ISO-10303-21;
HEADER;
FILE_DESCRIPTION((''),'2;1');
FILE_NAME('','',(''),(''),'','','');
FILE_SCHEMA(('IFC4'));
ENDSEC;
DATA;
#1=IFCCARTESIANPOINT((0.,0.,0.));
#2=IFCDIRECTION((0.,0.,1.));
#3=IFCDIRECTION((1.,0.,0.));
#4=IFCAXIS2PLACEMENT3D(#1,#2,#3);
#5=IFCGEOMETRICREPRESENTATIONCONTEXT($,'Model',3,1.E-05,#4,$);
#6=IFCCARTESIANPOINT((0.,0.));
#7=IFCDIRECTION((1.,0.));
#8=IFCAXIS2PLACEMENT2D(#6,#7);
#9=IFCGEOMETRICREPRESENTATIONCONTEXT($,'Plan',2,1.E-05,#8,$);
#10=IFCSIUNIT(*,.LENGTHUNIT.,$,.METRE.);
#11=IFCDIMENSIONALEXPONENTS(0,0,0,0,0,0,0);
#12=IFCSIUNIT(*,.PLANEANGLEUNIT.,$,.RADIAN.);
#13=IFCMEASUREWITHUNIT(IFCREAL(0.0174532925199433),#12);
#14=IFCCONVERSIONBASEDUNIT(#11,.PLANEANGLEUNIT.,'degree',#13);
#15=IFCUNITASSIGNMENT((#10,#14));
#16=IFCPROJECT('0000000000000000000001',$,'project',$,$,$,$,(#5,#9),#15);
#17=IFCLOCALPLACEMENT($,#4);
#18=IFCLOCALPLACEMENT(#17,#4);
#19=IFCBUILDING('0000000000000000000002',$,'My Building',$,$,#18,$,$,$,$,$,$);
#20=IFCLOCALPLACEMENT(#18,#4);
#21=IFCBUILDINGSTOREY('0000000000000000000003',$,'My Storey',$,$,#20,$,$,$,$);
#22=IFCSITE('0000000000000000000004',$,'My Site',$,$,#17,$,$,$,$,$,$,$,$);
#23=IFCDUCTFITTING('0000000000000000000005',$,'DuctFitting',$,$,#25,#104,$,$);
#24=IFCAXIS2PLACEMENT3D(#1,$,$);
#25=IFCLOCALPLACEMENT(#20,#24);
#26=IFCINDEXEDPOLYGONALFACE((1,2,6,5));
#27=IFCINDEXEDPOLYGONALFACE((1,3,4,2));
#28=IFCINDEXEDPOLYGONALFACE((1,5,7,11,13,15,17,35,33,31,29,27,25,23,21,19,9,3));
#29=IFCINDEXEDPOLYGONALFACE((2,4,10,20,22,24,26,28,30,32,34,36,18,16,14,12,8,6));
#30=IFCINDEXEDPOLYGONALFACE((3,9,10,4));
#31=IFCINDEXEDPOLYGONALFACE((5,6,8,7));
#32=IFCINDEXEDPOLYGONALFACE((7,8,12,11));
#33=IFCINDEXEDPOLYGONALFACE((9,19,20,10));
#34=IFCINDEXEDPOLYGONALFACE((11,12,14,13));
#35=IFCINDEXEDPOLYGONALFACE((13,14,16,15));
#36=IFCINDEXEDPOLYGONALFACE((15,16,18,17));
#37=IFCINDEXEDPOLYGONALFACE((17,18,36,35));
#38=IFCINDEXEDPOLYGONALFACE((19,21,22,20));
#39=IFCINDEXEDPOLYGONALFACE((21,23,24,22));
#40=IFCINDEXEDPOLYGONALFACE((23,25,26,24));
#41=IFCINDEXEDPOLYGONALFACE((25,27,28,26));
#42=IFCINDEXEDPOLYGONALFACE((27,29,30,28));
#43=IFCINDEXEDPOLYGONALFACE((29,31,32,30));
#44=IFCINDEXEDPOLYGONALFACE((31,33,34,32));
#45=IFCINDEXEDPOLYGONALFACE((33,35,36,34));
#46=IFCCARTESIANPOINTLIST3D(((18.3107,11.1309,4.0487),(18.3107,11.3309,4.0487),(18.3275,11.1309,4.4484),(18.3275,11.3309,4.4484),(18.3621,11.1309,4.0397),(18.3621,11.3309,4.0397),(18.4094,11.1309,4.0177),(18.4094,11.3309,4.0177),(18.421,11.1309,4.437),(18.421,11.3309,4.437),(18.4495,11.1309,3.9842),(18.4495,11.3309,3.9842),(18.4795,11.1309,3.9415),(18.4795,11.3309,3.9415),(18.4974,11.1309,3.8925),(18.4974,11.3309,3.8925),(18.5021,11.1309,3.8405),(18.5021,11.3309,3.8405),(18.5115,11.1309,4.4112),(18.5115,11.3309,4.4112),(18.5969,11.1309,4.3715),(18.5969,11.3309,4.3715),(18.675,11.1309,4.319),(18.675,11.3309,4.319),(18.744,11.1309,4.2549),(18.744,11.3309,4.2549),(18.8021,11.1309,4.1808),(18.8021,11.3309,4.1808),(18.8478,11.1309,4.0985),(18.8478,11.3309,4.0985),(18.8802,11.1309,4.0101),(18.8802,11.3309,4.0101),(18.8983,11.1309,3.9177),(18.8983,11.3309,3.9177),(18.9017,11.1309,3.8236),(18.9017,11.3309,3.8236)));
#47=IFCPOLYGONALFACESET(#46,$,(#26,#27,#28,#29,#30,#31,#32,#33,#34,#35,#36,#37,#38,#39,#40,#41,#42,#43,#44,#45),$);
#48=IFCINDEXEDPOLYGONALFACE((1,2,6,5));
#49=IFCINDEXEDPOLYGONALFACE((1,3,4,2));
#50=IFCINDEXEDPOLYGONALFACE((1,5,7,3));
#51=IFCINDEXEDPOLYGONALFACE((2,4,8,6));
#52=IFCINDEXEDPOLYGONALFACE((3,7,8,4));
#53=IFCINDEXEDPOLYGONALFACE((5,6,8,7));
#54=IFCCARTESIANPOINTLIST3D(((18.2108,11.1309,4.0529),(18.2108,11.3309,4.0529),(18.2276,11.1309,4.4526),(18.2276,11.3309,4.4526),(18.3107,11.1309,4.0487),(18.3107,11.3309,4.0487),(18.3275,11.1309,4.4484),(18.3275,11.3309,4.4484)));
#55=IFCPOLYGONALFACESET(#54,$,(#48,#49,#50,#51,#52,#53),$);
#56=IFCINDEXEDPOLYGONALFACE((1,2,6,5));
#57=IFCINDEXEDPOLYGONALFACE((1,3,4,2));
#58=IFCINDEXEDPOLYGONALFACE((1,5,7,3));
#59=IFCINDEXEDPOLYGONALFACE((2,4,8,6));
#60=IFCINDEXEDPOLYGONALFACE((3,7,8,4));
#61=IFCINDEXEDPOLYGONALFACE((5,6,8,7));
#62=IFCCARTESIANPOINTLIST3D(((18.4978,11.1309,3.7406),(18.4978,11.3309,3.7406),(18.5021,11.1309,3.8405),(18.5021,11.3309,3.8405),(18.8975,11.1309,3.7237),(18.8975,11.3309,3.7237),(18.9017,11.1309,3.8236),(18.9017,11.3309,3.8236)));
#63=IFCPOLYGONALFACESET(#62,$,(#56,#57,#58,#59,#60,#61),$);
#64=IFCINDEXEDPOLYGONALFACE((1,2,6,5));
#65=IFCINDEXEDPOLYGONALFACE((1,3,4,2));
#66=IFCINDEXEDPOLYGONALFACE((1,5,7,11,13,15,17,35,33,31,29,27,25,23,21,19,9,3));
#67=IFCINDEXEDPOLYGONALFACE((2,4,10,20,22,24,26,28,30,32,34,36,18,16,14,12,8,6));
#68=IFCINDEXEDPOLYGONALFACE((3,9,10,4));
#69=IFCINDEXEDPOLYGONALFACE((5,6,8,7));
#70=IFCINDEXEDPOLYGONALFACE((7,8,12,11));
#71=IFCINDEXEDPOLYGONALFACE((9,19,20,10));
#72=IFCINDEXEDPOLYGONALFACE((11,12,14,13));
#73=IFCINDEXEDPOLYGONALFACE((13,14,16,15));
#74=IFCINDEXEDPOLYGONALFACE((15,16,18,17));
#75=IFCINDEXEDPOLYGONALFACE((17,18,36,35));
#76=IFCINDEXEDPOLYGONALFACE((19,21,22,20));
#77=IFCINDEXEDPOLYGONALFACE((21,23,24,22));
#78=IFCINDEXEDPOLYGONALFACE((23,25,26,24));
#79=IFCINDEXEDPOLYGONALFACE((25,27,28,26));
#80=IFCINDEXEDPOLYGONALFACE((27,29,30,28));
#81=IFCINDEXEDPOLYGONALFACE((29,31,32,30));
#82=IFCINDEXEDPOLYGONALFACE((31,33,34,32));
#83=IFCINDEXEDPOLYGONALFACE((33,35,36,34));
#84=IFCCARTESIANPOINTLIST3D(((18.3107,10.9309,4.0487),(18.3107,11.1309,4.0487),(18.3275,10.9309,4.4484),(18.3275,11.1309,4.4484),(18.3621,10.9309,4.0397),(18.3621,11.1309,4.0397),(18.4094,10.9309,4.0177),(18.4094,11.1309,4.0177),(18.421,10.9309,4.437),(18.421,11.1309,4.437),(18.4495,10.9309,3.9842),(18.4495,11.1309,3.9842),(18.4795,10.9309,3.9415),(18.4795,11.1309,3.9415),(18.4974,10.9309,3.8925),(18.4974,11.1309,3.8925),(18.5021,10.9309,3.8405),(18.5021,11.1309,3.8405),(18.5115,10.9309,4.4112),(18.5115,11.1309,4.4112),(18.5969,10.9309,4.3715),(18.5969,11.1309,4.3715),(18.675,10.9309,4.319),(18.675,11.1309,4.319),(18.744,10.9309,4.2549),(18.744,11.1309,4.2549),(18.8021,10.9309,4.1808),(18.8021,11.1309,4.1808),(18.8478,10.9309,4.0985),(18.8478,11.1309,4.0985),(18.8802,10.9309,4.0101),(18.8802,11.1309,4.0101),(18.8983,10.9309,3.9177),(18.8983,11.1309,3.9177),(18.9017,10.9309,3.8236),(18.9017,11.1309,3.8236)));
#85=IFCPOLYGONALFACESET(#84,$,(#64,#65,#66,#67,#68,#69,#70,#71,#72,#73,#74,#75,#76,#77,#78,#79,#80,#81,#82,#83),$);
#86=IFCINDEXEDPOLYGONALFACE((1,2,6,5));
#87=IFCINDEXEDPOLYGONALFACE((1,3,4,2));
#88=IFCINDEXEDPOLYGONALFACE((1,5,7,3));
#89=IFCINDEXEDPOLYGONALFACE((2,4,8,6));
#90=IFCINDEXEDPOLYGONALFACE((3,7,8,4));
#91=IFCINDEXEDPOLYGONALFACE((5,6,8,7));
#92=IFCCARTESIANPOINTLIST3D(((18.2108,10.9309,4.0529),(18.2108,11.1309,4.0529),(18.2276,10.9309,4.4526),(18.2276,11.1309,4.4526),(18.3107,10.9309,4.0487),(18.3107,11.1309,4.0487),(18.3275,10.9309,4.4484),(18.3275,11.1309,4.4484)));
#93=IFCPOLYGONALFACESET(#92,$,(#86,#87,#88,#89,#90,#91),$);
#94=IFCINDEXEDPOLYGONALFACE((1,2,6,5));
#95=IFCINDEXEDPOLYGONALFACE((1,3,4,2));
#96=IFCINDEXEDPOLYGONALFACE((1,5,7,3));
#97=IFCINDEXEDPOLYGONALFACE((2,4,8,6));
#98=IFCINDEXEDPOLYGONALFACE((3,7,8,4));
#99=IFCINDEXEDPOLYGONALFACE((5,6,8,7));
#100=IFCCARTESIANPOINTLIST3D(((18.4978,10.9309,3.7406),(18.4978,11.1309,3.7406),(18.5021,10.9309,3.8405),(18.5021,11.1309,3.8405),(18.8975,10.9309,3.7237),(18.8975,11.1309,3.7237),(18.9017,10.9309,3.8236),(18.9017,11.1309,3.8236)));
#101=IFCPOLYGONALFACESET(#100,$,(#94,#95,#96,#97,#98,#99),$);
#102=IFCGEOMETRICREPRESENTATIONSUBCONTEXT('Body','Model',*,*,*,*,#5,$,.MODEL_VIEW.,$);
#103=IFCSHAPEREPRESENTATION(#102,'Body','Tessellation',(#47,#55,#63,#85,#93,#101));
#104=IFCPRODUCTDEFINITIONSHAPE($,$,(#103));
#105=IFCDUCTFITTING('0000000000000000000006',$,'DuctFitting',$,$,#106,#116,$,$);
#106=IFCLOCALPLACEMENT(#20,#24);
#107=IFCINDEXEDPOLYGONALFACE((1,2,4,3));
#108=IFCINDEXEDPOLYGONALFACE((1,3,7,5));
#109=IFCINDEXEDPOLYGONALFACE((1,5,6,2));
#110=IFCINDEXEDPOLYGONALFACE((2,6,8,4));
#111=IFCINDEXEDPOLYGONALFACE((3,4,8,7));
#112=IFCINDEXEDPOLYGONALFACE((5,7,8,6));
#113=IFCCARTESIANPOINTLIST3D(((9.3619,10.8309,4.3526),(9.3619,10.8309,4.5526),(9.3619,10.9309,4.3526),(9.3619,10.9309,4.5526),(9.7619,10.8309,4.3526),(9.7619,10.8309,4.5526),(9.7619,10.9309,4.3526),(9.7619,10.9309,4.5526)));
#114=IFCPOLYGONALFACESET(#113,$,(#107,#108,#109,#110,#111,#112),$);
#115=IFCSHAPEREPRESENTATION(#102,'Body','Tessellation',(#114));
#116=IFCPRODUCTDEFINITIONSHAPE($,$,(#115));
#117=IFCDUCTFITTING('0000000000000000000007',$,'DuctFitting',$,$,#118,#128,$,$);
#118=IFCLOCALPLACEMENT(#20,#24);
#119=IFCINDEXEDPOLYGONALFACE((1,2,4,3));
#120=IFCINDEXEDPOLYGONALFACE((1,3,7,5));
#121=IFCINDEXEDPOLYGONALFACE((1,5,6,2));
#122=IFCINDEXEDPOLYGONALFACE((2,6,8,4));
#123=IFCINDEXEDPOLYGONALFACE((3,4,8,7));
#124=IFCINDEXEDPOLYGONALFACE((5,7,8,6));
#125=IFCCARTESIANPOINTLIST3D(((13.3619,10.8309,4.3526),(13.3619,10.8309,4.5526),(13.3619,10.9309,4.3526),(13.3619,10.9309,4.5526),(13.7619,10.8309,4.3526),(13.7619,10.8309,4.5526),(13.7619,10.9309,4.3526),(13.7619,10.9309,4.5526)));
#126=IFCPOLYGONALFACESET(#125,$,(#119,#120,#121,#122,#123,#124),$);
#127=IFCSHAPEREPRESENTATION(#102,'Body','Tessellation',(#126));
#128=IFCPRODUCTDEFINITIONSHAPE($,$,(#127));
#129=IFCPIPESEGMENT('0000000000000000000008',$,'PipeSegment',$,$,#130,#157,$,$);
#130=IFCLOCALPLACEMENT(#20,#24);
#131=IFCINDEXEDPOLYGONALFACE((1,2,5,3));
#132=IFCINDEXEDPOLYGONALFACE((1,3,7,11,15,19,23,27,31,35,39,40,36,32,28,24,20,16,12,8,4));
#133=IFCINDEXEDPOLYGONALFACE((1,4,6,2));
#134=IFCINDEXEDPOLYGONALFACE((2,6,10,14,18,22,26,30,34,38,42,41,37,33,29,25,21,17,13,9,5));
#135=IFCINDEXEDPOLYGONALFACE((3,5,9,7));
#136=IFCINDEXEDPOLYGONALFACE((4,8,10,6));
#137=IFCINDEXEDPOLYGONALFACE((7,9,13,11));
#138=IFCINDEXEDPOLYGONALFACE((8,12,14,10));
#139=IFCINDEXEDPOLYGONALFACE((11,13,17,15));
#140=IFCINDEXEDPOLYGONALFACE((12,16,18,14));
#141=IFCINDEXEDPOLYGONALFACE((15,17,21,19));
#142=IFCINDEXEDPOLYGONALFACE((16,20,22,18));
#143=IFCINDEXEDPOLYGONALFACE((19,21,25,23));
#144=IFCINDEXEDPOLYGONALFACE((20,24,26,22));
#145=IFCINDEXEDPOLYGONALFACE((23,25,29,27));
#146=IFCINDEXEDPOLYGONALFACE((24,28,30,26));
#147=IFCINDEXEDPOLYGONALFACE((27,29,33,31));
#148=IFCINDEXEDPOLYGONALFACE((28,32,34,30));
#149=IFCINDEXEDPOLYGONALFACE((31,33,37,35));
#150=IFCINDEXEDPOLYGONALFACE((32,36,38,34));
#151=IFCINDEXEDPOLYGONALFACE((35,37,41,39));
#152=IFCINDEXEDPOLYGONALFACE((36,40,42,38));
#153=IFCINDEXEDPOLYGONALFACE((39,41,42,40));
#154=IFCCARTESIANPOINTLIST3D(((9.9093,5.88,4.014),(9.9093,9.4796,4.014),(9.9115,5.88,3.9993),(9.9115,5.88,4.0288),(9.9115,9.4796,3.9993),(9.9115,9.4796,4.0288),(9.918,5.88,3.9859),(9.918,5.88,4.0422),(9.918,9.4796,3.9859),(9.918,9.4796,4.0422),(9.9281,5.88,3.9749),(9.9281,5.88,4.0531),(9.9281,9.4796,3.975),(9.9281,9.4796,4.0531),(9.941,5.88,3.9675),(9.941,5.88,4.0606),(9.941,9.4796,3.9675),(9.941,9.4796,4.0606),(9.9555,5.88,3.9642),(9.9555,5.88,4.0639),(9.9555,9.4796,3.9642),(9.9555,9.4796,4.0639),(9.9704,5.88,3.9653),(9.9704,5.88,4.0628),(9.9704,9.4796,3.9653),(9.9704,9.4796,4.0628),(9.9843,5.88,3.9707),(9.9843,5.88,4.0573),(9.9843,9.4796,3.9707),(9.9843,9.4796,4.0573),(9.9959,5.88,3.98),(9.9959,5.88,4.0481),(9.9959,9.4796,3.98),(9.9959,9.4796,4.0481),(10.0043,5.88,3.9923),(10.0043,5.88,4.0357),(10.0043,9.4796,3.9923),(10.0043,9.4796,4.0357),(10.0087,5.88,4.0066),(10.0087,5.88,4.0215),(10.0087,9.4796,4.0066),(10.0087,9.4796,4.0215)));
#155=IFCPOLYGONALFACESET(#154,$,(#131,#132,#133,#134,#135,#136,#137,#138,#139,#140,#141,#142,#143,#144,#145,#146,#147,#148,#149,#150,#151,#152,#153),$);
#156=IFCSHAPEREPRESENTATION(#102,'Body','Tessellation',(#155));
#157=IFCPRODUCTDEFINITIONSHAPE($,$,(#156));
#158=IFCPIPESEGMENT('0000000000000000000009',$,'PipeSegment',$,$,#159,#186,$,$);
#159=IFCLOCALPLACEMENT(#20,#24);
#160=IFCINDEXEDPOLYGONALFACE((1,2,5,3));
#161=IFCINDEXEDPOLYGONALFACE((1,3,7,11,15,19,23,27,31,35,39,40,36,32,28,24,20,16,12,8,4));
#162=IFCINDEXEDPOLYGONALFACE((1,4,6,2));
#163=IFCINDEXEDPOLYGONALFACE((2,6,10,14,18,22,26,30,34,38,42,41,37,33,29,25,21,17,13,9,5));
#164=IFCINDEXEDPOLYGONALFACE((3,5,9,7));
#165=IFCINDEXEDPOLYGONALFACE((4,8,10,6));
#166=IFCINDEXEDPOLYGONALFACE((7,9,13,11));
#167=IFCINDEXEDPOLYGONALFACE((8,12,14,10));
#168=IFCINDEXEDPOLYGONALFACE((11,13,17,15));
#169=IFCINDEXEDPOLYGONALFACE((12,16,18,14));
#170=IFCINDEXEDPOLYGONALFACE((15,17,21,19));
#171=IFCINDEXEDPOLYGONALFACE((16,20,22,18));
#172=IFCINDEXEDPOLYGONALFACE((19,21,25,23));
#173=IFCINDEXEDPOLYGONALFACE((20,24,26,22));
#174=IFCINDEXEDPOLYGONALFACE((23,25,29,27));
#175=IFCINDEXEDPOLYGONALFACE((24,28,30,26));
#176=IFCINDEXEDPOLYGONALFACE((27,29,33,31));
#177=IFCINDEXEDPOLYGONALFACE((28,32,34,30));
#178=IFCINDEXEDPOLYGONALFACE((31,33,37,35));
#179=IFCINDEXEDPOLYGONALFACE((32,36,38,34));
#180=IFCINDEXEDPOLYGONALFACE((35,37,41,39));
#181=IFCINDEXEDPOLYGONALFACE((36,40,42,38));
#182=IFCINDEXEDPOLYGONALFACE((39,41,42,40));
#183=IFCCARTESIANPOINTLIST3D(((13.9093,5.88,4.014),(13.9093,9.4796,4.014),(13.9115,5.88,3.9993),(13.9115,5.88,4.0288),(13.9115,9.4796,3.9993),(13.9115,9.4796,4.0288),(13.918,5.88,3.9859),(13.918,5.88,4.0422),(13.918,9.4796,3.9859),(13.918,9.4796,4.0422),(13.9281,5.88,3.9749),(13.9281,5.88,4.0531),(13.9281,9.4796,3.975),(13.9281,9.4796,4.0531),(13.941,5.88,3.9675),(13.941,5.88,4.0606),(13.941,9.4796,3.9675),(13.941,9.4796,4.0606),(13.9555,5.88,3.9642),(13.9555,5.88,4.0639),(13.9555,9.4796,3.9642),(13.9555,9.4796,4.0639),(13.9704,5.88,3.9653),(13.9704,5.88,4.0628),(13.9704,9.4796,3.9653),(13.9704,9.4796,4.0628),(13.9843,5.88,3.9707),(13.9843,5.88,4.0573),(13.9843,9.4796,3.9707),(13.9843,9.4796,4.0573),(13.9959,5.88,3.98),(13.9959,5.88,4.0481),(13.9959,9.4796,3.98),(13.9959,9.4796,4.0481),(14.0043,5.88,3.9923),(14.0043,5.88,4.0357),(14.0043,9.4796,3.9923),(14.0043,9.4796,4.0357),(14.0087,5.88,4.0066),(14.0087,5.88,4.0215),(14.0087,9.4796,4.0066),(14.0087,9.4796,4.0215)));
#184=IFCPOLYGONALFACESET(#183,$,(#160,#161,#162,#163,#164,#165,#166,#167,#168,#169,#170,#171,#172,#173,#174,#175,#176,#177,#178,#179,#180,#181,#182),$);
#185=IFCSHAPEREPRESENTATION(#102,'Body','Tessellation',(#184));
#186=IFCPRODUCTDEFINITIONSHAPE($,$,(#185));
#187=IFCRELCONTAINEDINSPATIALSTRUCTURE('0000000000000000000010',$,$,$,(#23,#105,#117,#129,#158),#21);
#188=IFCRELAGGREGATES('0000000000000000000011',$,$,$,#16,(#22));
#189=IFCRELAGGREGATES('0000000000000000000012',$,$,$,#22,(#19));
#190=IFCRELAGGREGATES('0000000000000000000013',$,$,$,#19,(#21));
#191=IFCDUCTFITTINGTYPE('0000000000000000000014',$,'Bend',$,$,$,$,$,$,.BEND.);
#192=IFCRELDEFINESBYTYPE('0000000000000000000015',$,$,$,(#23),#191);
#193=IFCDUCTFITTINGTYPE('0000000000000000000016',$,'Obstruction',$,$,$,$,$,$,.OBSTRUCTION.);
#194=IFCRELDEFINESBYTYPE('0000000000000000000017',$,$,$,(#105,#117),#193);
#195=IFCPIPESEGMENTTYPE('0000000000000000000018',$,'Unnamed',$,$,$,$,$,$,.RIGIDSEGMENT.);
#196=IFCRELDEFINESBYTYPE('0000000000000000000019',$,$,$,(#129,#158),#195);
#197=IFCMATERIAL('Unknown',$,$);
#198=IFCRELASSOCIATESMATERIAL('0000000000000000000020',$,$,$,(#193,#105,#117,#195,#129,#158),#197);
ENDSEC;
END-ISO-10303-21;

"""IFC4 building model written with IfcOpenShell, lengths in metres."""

from ifc_helpers import new_model, entity, si_unit, converted_unit, frame, origin_with_axes, origin_2d_with_axis, place, context, subcontext, project, spatial, line, arc, indexed_curve, rectangle, circle, outline, extrude, source, transform, mapped, material, material_profile, profile_set, profile_usage, type_object, type_shapes, element, save


model = new_model("IFC4")

# Units and contexts
model_context = context("Model", 3, precision=1e-05, world=origin_with_axes())
plan_context = context("Plan", 2, precision=1e-05, world=origin_2d_with_axis())
body_context_1 = subcontext(model_context, "Body", "Model", "MODEL_VIEW")
ifc_project = project(units=[si_unit("LENGTHUNIT", "METRE"), converted_unit("PLANEANGLEUNIT", "degree", entity("IfcReal", 0.0174532925199433), si_unit("PLANEANGLEUNIT", "RADIAN"), dimensions=[0, 0, 0, 0, 0, 0, 0])], contexts=[model_context, plan_context])

# Site, building, storey
site_placement = place(None, origin_with_axes())
site = spatial("IfcSite", under=ifc_project, at=site_placement, Name="My Site")
building_placement = place(site_placement, origin_with_axes())
building = spatial("IfcBuilding", under=site, at=building_placement, Name="My Building")
storey_placement = place(building_placement, origin_with_axes())
storey = spatial("IfcBuildingStorey", under=building, at=storey_placement, Name="My Storey")

# Shared definitions
ifc_material = material(Name="Unknown")

# Duct fittings
duct_fitting_type_1 = type_object("IfcDuctFittingType", Name="Bend", PredefinedType="BEND")
shared_shape_1 = source(origin_with_axes(), body_context_1, "Body", "SweptSolid", [
    extrude(outline(indexed_curve([(0.2, 0.0), (0.2586, 0.1414), (0.4, 0.2), (0.4, 0.6), (-0.0243, 0.4243), (-0.2, 0.0)], segments=[arc(1, 2, 3), line(3, 4), arc(4, 5, 6), line(6, 1)])), frame((0.0, -0.1, 0.1), z_axis=(0.0, -1.0, 0.0), x_axis=(1.0, 0.0, 0.0)), (0.0, 0.0, -1.0), 0.2),
    extrude(rectangle(XDim=0.4, YDim=0.2), origin_with_axes(), (0.0, 0.0, 1.0), 0.1),
    extrude(rectangle(XDim=0.4, YDim=0.2), frame((0.4, 0.0, 0.5), z_axis=(1.0, 0.0, 0.0), x_axis=(0.0, 0.0, 1.0)), (0.0, 0.0, 1.0), 0.1),
    extrude(outline(indexed_curve([(0.2, 0.0), (0.2586, 0.1414), (0.4, 0.2), (0.4, 0.6), (-0.0243, 0.4243), (-0.2, 0.0)], segments=[arc(1, 2, 3), line(3, 4), arc(4, 5, 6), line(6, 1)])), frame((0.0, -0.3, 0.1), z_axis=(0.0, -1.0, 0.0), x_axis=(1.0, 0.0, 0.0)), (0.0, 0.0, -1.0), 0.2),
    extrude(rectangle(XDim=0.4, YDim=0.2), frame((0.0, -0.2, 0.0), z_axis=(0.0, 0.0, 1.0), x_axis=(1.0, 0.0, 0.0)), (0.0, 0.0, 1.0), 0.1),
    extrude(rectangle(XDim=0.4, YDim=0.2), frame((0.4, -0.2, 0.5), z_axis=(1.0, 0.0, 0.0), x_axis=(0.0, 0.0, 1.0)), (0.0, 0.0, 1.0), 0.1),
])
type_shapes(duct_fitting_type_1, [shared_shape_1])
duct_fitting_1_placement = place(storey_placement, frame((18.2192, 11.2309, 4.2527), z_axis=(0.999112, 0.0, -0.042141), x_axis=(-0.042141, 0.0, -0.999112)))
element("IfcDuctFitting", 1, at=duct_fitting_1_placement, inside=storey, type_object=duct_fitting_type_1, Name="DuctFitting", context=body_context_1, shape_type="MappedRepresentation", body=[
    mapped(shared_shape_1, transform((0.0, 0.0, 0.0), x_axis=(1.0, 0.0, 0.0), y_axis=(0.0, 1.0, 0.0), z_axis=(0.0, 0.0, 1.0), scale=1.0)),
])
ifc_material_profile_1 = material_profile(ifc_material, rectangle(XDim=0.4, YDim=0.2))
ifc_profile_set_1 = profile_set([ifc_material_profile_1])
ifc_profile_usage_1 = profile_usage(ifc_profile_set_1, cardinal=5)
duct_fitting_type_2 = type_object("IfcDuctFittingType", Name="Obstruction", PredefinedType="OBSTRUCTION", material=ifc_profile_set_1)
duct_fitting_2_placement = place(storey_placement, frame((9.5619, 10.9309, 4.4526), z_axis=(0.0, -1.0, 0.0), x_axis=(1.0, 0.0, 0.0)))
element("IfcDuctFitting", 2, at=duct_fitting_2_placement, inside=storey, type_object=duct_fitting_type_2, material=ifc_profile_usage_1, Name="DuctFitting", context=body_context_1, shape_type="SweptSolid", body=[
    extrude(rectangle(XDim=0.4, YDim=0.2), origin_with_axes(), (0.0, 0.0, 1.0), 0.1),
])
ifc_profile_usage_2 = profile_usage(ifc_profile_set_1, cardinal=5)
duct_fitting_3_placement = place(storey_placement, frame((13.5619, 10.9309, 4.4526), z_axis=(0.0, -1.0, 0.0), x_axis=(1.0, 0.0, 0.0)))
element("IfcDuctFitting", 3, at=duct_fitting_3_placement, inside=storey, type_object=duct_fitting_type_2, material=ifc_profile_usage_2, Name="DuctFitting", context=body_context_1, shape_type="SweptSolid", body=[
    extrude(rectangle(XDim=0.4, YDim=0.2), origin_with_axes(), (0.0, 0.0, 1.0), 0.1),
])

# Pipe segments
ifc_material_profile_2 = material_profile(ifc_material, circle(Radius=0.05))
ifc_profile_set_2 = profile_set([ifc_material_profile_2])
ifc_profile_usage_3 = profile_usage(ifc_profile_set_2, cardinal=5)
pipe_segment_type = type_object("IfcPipeSegmentType", Name="Unnamed", PredefinedType="RIGIDSEGMENT", material=ifc_profile_set_2)
pipe_segment_1_placement = place(storey_placement, frame((9.9593, 5.88, 4.014), z_axis=(0.0, 1.0, 0.0), x_axis=(-1.0, 0.0, 0.0)))
element("IfcPipeSegment", 4, at=pipe_segment_1_placement, inside=storey, type_object=pipe_segment_type, material=ifc_profile_usage_3, Name="PipeSegment", context=body_context_1, shape_type="SweptSolid", body=[
    extrude(circle(Radius=0.05), origin_with_axes(), (0.0, 0.0, 1.0), 3.5996),
])
ifc_profile_usage_4 = profile_usage(ifc_profile_set_2, cardinal=5)
pipe_segment_2_placement = place(storey_placement, frame((13.9593, 5.88, 4.014), z_axis=(0.0, 1.0, 0.0), x_axis=(-1.0, 0.0, 0.0)))
element("IfcPipeSegment", 5, at=pipe_segment_2_placement, inside=storey, type_object=pipe_segment_type, material=ifc_profile_usage_4, Name="PipeSegment", context=body_context_1, shape_type="SweptSolid", body=[
    extrude(circle(Radius=0.05), origin_with_axes(), (0.0, 0.0, 1.0), 3.5996),
])

save(model, "model.ifc")
